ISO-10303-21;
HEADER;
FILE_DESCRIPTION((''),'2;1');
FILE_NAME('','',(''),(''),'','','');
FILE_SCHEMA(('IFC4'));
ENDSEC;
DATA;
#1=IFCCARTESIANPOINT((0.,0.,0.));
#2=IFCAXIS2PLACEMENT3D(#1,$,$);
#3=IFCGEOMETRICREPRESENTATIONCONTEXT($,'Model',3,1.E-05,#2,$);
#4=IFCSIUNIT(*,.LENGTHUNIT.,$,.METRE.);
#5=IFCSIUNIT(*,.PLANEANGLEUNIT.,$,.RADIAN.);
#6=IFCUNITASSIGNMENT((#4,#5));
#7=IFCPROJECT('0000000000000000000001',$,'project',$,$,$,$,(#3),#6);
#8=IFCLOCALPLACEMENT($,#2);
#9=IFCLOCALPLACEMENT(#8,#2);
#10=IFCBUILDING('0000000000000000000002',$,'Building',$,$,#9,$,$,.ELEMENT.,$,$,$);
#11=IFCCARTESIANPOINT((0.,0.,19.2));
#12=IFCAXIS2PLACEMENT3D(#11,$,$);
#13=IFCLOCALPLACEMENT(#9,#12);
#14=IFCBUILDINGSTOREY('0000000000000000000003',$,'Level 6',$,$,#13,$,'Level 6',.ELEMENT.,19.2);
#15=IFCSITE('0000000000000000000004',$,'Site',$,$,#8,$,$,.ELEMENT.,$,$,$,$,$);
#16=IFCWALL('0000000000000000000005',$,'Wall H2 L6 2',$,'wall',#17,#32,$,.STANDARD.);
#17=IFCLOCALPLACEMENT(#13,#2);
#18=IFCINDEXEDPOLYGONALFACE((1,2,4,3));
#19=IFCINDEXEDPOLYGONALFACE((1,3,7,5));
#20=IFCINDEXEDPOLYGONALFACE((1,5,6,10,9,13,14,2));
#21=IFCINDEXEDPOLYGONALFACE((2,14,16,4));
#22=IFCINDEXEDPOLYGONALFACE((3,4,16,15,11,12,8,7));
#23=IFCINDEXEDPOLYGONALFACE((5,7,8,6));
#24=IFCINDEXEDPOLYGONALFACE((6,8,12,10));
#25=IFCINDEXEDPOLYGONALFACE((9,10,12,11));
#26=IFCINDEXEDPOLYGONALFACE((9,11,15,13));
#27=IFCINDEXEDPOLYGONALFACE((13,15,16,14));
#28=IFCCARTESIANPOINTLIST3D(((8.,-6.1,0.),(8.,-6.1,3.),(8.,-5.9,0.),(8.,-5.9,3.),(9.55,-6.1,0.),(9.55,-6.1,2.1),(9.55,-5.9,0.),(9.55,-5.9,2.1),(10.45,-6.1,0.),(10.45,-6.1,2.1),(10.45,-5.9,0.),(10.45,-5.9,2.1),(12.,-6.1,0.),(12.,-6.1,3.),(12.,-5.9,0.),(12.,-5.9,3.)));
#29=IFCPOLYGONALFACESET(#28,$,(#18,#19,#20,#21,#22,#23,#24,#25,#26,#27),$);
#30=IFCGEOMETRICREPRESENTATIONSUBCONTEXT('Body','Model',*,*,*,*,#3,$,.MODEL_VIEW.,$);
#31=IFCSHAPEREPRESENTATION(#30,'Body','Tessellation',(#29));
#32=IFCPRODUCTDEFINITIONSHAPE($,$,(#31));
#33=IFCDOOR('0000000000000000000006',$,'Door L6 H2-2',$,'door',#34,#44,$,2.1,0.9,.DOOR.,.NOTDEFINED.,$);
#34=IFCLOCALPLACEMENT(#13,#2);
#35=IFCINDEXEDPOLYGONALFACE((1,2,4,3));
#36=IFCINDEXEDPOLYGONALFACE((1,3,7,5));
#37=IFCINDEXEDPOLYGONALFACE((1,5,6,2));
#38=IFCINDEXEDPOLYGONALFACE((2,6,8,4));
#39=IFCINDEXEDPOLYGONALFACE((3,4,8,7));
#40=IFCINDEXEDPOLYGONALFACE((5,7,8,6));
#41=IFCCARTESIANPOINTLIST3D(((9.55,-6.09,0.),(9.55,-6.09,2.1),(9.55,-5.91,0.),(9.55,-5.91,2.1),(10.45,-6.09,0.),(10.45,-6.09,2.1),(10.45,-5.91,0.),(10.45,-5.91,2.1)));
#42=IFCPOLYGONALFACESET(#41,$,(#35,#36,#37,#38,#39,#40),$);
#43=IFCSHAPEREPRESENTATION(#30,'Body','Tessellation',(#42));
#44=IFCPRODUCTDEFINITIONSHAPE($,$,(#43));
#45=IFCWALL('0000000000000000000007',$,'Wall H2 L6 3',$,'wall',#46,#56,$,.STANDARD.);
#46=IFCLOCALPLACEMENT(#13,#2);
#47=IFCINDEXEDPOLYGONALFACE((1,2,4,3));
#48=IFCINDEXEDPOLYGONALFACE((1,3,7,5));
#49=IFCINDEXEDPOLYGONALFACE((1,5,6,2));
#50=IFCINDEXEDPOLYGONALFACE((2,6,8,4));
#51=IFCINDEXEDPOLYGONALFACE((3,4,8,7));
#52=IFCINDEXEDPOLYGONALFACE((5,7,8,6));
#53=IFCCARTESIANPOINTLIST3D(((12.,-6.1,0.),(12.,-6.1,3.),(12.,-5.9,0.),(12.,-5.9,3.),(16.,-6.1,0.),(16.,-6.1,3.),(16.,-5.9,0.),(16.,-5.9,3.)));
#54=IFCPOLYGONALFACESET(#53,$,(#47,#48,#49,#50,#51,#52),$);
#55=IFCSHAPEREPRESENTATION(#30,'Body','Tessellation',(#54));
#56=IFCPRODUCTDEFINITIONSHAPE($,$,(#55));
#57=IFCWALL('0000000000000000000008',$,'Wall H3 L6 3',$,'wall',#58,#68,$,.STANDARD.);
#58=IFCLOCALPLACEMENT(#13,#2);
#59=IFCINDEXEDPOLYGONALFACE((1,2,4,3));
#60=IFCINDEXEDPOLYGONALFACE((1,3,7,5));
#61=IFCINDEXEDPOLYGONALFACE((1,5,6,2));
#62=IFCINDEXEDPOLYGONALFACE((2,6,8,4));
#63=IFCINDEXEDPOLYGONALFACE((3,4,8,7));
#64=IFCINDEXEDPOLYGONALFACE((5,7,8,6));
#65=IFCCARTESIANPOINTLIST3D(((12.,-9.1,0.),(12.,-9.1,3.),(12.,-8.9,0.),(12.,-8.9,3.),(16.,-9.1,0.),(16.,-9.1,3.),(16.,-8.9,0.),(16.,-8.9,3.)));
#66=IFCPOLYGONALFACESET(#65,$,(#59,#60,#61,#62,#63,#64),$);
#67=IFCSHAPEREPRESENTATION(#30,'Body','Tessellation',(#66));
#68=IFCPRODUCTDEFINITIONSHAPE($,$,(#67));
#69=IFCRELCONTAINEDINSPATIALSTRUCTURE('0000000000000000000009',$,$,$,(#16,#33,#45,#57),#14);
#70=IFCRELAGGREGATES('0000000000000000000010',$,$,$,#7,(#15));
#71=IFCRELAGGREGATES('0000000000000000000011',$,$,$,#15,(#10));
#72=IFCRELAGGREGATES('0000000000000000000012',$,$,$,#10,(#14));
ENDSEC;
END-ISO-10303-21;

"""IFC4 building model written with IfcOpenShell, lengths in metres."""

from ifc_helpers import new_model, si_unit, frame, frame_2d, origin, origin_2d, place, context, subcontext, project, spatial, rectangle, extrude, element, fill, save


model = new_model("IFC4")

# Units and contexts
model_context = context("Model", 3, precision=1e-05, world=origin())
body_context = subcontext(model_context, "Body", "Model", "MODEL_VIEW")
ifc_project = project(units=[si_unit("LENGTHUNIT", "METRE"), si_unit("PLANEANGLEUNIT", "RADIAN")], contexts=[model_context])

# Site, building, storey
site_placement = place(None, origin())
site = spatial("IfcSite", under=ifc_project, at=site_placement, Name="Site", CompositionType="ELEMENT")
building_placement = place(site_placement, origin())
building = spatial("IfcBuilding", under=site, at=building_placement, Name="Building", CompositionType="ELEMENT")
storey_placement = place(building_placement, frame((0.0, 0.0, 19.2)))
storey = spatial("IfcBuildingStorey", under=building, at=storey_placement, Name="Level 6", LongName="Level 6", CompositionType="ELEMENT", Elevation=19.2)

# Wall, opening, door
wall_1_placement = place(storey_placement, frame((8.0, -6.0, 0.0), z_axis=(0.0, 0.0, 1.0), x_axis=(1.0, 0.0, 0.0)))
wall_1 = element("IfcWall", 1, at=wall_1_placement, inside=storey, Name="Wall H2 L6 2", ObjectType="wall", PredefinedType="STANDARD", context=body_context, shape_type="SweptSolid", body=[
    extrude(rectangle(XDim=4.0, YDim=0.2, at=frame_2d((2.0, 0.0))), origin(), (0.0, 0.0, 1.0), 3.0),
])
opening_1_placement = place(storey_placement, frame((10.0, -6.0, 0.0), z_axis=(0.0, 0.0, 1.0), x_axis=(1.0, 0.0, 0.0)))
opening_1 = element("IfcOpeningElement", 2, at=opening_1_placement, cuts=wall_1, ObjectType="Opening", PredefinedType="OPENING", context=body_context, shape_type="SweptSolid", body=[
    extrude(rectangle(XDim=0.9, YDim=0.22, at=origin_2d()), origin(), (0.0, 0.0, 1.0), 2.1),
])
door_1_placement = place(storey_placement, frame((10.0, -6.0, 0.0), z_axis=(0.0, 0.0, 1.0), x_axis=(1.0, 0.0, 0.0)))
door_1 = element("IfcDoor", 3, at=door_1_placement, inside=storey, Name="Door L6 H2-2", ObjectType="door", OperationType="NOTDEFINED", OverallHeight=2.1, OverallWidth=0.9, PredefinedType="DOOR", context=body_context, shape_type="SweptSolid", body=[
    extrude(rectangle(XDim=0.9, YDim=0.18, at=origin_2d()), origin(), (0.0, 0.0, 1.0), 2.1),
])
fill(opening_1, door_1)

# Walls
for number, where, z_axis, x_axis, name in (
    (4, (12.0, -6.0, 0.0), (0.0, 0.0, 1.0), (1.0, 0.0, 0.0), "Wall H2 L6 3"),
    (5, (12.0, -9.0, 0.0), (0.0, 0.0, 1.0), (1.0, 0.0, 0.0), "Wall H3 L6 3"),
):
    element("IfcWall", number, at=place(storey_placement, frame(where, z_axis=z_axis, x_axis=x_axis)), inside=storey, Name=name, ObjectType="wall", PredefinedType="STANDARD", context=body_context, shape_type="SweptSolid", body=[
        extrude(rectangle(XDim=4.0, YDim=0.2, at=frame_2d((2.0, 0.0))), origin(), (0.0, 0.0, 1.0), 3.0),
    ])

save(model, "model.ifc")
